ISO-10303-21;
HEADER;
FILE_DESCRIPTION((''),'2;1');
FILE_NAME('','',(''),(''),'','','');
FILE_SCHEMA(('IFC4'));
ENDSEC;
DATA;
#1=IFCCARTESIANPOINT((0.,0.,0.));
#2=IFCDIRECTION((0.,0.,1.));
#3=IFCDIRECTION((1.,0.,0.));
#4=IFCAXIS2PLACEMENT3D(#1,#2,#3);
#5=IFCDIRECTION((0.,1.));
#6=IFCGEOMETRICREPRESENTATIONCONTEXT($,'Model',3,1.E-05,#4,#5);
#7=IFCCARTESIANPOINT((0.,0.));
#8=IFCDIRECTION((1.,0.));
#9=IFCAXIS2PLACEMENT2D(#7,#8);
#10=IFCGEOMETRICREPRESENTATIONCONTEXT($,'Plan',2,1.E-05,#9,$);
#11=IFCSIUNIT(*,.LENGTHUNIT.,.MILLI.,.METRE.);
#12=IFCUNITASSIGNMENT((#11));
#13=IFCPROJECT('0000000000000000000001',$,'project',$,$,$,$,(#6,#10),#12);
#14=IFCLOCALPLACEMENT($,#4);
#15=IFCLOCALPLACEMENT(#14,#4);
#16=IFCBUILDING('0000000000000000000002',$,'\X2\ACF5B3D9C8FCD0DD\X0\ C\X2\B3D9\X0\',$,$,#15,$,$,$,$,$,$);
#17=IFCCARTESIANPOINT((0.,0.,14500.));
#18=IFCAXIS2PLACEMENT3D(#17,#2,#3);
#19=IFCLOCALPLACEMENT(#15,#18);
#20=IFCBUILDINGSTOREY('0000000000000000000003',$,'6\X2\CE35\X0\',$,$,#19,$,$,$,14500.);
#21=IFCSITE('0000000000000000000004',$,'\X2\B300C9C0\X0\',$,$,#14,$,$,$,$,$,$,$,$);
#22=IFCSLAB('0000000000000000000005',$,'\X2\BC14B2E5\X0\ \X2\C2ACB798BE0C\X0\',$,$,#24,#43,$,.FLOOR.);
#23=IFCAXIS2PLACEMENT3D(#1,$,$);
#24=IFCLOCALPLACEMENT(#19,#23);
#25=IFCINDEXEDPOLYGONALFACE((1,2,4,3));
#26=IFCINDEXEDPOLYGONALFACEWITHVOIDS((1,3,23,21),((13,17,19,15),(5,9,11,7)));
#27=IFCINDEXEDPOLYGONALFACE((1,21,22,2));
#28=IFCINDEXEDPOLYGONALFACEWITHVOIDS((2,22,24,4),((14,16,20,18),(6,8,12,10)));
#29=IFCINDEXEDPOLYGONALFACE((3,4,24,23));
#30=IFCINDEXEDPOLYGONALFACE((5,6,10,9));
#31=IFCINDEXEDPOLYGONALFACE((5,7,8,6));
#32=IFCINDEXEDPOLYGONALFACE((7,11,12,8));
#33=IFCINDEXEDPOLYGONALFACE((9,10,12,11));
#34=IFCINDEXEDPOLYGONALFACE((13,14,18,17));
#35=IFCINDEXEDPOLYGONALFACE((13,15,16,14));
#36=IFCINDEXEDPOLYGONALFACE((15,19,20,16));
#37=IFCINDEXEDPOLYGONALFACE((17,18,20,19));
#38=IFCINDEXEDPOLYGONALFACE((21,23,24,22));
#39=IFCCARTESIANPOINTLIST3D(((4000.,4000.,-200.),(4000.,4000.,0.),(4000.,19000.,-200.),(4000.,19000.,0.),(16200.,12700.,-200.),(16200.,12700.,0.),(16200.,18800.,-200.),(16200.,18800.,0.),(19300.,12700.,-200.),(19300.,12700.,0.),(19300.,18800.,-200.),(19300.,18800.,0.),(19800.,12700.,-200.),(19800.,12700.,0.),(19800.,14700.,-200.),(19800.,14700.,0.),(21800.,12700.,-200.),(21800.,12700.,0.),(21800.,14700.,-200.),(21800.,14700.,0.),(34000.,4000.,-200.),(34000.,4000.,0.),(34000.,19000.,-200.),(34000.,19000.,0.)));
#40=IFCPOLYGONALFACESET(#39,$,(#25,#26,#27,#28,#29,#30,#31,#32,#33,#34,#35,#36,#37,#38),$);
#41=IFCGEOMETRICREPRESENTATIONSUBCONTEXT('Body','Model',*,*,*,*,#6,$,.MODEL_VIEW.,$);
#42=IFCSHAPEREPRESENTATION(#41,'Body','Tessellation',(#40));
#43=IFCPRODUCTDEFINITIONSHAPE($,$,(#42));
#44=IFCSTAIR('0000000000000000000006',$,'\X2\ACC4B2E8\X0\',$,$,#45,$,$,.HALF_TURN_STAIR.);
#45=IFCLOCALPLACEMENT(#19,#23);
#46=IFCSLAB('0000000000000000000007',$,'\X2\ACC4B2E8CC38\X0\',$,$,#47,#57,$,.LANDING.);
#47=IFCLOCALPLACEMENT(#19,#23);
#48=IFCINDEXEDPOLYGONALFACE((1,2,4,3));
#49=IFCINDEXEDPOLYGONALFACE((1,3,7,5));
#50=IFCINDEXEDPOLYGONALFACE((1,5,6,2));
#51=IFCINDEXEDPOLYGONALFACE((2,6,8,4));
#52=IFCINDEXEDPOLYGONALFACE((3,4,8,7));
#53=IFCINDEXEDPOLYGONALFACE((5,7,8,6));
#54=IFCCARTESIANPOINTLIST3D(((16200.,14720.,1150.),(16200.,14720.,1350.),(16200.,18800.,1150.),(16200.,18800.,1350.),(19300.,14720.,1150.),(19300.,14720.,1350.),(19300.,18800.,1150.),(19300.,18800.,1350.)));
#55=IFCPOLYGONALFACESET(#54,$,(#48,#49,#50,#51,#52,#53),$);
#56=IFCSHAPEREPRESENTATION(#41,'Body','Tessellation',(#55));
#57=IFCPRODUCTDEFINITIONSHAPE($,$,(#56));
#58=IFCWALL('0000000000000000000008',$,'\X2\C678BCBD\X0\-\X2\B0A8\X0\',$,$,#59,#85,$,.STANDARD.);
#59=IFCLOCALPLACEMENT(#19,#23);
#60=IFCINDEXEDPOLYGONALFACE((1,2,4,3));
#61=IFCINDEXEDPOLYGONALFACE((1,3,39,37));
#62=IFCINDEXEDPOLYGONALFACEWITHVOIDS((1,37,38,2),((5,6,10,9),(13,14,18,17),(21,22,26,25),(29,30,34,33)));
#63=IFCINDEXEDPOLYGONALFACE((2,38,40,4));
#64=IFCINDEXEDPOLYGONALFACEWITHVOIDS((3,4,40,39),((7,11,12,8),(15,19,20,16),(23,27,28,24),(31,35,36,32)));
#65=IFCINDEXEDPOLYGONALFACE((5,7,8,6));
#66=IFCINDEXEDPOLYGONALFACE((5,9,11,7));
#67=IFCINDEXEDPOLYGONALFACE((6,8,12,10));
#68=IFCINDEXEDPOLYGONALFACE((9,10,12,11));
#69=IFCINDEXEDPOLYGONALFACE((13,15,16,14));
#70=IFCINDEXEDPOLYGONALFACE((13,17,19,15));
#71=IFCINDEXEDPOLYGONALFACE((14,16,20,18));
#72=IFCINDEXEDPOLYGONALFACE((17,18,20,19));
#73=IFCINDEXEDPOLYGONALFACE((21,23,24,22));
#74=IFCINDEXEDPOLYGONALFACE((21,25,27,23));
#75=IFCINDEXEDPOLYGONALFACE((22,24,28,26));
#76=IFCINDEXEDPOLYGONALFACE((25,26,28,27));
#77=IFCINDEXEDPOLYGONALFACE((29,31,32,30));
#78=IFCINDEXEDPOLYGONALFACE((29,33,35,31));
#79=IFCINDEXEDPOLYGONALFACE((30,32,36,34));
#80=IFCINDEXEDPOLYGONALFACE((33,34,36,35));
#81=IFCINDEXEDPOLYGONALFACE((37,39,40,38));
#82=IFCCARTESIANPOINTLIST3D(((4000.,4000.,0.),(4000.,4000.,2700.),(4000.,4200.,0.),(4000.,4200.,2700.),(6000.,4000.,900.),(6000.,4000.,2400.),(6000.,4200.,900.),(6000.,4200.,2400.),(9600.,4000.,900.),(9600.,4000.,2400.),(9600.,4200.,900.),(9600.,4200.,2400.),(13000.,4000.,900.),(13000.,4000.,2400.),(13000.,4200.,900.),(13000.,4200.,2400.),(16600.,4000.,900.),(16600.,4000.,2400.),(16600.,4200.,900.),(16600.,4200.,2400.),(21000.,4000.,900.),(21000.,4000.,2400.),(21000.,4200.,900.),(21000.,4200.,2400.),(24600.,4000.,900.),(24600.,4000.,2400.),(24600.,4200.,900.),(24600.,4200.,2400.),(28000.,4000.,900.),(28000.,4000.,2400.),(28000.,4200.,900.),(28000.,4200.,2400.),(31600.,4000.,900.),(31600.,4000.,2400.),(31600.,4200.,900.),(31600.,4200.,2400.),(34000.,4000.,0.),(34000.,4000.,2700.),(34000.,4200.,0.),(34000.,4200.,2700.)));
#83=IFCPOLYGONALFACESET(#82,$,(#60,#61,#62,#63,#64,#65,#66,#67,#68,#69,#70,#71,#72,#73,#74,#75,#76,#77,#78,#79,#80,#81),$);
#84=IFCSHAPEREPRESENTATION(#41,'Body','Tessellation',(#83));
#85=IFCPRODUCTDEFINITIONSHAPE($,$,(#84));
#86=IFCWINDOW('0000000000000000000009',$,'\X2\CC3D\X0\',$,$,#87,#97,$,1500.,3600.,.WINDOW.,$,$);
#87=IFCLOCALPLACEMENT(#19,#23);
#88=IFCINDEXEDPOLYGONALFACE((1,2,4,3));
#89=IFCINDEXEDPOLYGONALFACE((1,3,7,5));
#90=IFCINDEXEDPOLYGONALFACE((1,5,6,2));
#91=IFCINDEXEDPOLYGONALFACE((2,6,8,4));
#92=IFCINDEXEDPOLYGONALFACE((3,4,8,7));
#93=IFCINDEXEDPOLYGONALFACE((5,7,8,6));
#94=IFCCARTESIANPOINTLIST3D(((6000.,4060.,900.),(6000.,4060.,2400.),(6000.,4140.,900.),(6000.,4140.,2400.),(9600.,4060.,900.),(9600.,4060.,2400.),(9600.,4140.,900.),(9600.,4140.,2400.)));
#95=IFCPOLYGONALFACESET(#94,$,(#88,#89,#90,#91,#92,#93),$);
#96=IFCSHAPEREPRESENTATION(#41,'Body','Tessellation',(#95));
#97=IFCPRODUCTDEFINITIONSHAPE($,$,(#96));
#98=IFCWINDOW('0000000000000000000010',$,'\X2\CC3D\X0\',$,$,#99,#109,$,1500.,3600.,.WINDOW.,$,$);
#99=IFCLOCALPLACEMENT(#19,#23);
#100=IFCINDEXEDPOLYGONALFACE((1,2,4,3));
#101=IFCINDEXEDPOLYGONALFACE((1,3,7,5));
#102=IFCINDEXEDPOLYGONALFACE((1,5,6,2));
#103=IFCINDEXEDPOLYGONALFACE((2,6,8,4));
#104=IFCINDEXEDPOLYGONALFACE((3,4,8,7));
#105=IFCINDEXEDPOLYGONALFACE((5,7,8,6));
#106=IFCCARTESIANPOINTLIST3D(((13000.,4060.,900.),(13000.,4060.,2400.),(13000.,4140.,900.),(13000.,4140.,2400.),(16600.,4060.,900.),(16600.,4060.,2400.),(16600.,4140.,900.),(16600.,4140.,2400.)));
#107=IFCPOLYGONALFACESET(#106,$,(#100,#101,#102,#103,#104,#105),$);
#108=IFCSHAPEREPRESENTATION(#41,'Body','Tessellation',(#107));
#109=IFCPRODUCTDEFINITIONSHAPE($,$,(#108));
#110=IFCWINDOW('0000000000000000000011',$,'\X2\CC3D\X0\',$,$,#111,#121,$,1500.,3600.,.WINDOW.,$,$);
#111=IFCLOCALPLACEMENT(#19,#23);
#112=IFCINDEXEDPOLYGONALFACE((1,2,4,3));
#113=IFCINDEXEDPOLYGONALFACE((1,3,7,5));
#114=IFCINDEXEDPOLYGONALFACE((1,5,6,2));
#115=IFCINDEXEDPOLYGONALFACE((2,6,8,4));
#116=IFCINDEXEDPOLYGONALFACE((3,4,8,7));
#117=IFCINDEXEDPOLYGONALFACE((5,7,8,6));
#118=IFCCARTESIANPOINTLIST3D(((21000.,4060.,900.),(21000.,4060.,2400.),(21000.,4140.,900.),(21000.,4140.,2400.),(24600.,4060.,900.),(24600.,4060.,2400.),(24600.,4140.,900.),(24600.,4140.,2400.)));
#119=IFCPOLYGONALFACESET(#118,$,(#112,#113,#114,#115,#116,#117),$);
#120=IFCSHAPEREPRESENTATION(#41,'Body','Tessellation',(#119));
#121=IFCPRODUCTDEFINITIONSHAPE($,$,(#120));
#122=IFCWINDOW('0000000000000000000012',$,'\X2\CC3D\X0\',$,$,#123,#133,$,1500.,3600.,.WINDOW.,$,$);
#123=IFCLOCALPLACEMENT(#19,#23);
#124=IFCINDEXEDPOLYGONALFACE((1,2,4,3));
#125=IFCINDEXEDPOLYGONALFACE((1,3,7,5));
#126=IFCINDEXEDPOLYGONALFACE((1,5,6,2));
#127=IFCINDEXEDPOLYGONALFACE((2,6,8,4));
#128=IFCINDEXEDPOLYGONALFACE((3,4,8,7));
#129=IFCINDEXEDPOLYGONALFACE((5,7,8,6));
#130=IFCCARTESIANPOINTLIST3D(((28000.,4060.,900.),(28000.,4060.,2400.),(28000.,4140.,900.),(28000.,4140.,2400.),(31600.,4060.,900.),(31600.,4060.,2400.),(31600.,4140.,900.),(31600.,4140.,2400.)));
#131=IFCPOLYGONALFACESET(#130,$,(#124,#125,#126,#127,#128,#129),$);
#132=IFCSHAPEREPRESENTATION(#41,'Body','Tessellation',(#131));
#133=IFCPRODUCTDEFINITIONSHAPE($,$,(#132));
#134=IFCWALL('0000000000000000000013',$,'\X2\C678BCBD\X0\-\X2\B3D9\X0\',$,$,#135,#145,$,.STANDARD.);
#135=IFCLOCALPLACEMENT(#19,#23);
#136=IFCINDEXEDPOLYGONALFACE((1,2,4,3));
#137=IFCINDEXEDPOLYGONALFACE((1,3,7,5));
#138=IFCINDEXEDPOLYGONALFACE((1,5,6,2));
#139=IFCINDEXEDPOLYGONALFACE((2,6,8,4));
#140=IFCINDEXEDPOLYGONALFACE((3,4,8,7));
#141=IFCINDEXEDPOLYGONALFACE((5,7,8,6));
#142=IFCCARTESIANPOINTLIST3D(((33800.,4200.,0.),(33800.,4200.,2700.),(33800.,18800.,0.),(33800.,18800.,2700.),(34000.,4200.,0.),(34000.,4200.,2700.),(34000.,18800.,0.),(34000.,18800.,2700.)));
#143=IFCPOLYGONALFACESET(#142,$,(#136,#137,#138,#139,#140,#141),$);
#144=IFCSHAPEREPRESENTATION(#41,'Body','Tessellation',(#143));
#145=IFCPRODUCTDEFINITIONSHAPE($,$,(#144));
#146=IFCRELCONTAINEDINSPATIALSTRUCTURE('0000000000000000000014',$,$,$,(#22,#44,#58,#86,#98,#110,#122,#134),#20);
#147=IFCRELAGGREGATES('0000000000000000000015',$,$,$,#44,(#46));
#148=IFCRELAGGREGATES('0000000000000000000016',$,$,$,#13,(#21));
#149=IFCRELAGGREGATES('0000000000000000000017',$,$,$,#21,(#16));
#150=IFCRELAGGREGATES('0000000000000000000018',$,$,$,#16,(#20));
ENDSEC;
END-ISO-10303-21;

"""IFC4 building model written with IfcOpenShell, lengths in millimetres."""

from ifc_helpers import new_model, si_unit, direction, frame, origin_with_axes, origin_2d_with_axis, place, context, subcontext, project, spatial, polyline, outline, extrude, element, fill, aggregate, save


model = new_model("IFC4")

# Units and contexts
model_context = context("Model", 3, precision=1e-05, world=origin_with_axes(), true_north=direction((0.0, 1.0)))
plan_context = context("Plan", 2, precision=1e-05, world=origin_2d_with_axis())
body_context = subcontext(model_context, "Body", "Model", "MODEL_VIEW")
ifc_project = project(units=[si_unit("LENGTHUNIT", "METRE", prefix="MILLI")], contexts=[model_context, plan_context])

# Site, building, storey
site_placement = place(None, origin_with_axes())
site = spatial("IfcSite", under=ifc_project, at=site_placement, Name="대지")
building_placement = place(site_placement, origin_with_axes())
building = spatial("IfcBuilding", under=site, at=building_placement, Name="공동주택 C동")
storey_placement = place(building_placement, frame((0.0, 0.0, 14500.0), z_axis=(0.0, 0.0, 1.0), x_axis=(1.0, 0.0, 0.0)))
storey = spatial("IfcBuildingStorey", under=building, at=storey_placement, Name="6층", Elevation=14500.0)

# Slab
slab_1_placement = place(storey_placement, origin_with_axes())
element("IfcSlab", 1, at=slab_1_placement, inside=storey, Name="바닥 슬래브", PredefinedType="FLOOR", context=body_context, shape_type="SweptSolid", body=[
    extrude(outline(polyline([(4000.0, 4000.0), (34000.0, 4000.0), (34000.0, 19000.0), (4000.0, 19000.0), (4000.0, 4000.0)]), holes=[polyline([(16200.0, 12700.0), (19300.0, 12700.0), (19300.0, 18800.0), (16200.0, 18800.0), (16200.0, 12700.0)]), polyline([(19800.0, 12700.0), (21800.0, 12700.0), (21800.0, 14700.0), (19800.0, 14700.0), (19800.0, 12700.0)])]), frame((0.0, 0.0, -200.0), z_axis=(0.0, 0.0, 1.0), x_axis=(1.0, 0.0, 0.0)), (0.0, 0.0, 1.0), 200.0),
])

# Stair, slab
stair_placement = place(storey_placement, origin_with_axes())
stair = element("IfcStair", 2, at=stair_placement, inside=storey, Name="계단", PredefinedType="HALF_TURN_STAIR")
slab_2_placement = place(stair_placement, origin_with_axes())
slab_2 = element("IfcSlab", 3, at=slab_2_placement, Name="계단참", PredefinedType="LANDING", context=body_context, shape_type="SweptSolid", body=[
    extrude(outline(polyline([(16200.0, 14720.0), (19300.0, 14720.0), (19300.0, 18800.0), (16200.0, 18800.0), (16200.0, 14720.0)])), frame((0.0, 0.0, 1150.0), z_axis=(0.0, 0.0, 1.0), x_axis=(1.0, 0.0, 0.0)), (0.0, 0.0, 1.0), 200.0),
])

# Wall, openings, windows
wall_1_placement = place(storey_placement, origin_with_axes())
wall_1 = element("IfcWall", 4, at=wall_1_placement, inside=storey, Name="외벽-남", PredefinedType="STANDARD", context=body_context, shape_type="SweptSolid", body=[
    extrude(outline(polyline([(4000.0, 4200.0), (34000.0, 4200.0), (34000.0, 4000.0), (4000.0, 4000.0), (4000.0, 4200.0)])), origin_with_axes(), (0.0, 0.0, 1.0), 2700.0),
])
opening_1_placement = place(storey_placement, origin_with_axes())
opening_1 = element("IfcOpeningElement", 5, at=opening_1_placement, cuts=wall_1, PredefinedType="OPENING", context=body_context, shape_type="SweptSolid", body=[
    extrude(outline(polyline([(6000.0, 3950.0), (9600.0, 3950.0), (9600.0, 4250.0), (6000.0, 4250.0), (6000.0, 3950.0)])), frame((0.0, 0.0, 900.0), z_axis=(0.0, 0.0, 1.0), x_axis=(1.0, 0.0, 0.0)), (0.0, 0.0, 1.0), 1500.0),
])
opening_2_placement = place(storey_placement, origin_with_axes())
opening_2 = element("IfcOpeningElement", 6, at=opening_2_placement, cuts=wall_1, PredefinedType="OPENING", context=body_context, shape_type="SweptSolid", body=[
    extrude(outline(polyline([(13000.0, 3950.0), (16600.0, 3950.0), (16600.0, 4250.0), (13000.0, 4250.0), (13000.0, 3950.0)])), frame((0.0, 0.0, 900.0), z_axis=(0.0, 0.0, 1.0), x_axis=(1.0, 0.0, 0.0)), (0.0, 0.0, 1.0), 1500.0),
])
opening_3_placement = place(storey_placement, origin_with_axes())
opening_3 = element("IfcOpeningElement", 7, at=opening_3_placement, cuts=wall_1, PredefinedType="OPENING", context=body_context, shape_type="SweptSolid", body=[
    extrude(outline(polyline([(21000.0, 3950.0), (24600.0, 3950.0), (24600.0, 4250.0), (21000.0, 4250.0), (21000.0, 3950.0)])), frame((0.0, 0.0, 900.0), z_axis=(0.0, 0.0, 1.0), x_axis=(1.0, 0.0, 0.0)), (0.0, 0.0, 1.0), 1500.0),
])
opening_4_placement = place(storey_placement, origin_with_axes())
opening_4 = element("IfcOpeningElement", 8, at=opening_4_placement, cuts=wall_1, PredefinedType="OPENING", context=body_context, shape_type="SweptSolid", body=[
    extrude(outline(polyline([(28000.0, 3950.0), (31600.0, 3950.0), (31600.0, 4250.0), (28000.0, 4250.0), (28000.0, 3950.0)])), frame((0.0, 0.0, 900.0), z_axis=(0.0, 0.0, 1.0), x_axis=(1.0, 0.0, 0.0)), (0.0, 0.0, 1.0), 1500.0),
])
window_1_placement = place(storey_placement, origin_with_axes())
window_1 = element("IfcWindow", 9, at=window_1_placement, inside=storey, Name="창", OverallHeight=1500.0, OverallWidth=3600.0, PredefinedType="WINDOW", context=body_context, shape_type="SweptSolid", body=[
    extrude(outline(polyline([(6000.0, 4060.0), (9600.0, 4060.0), (9600.0, 4140.0), (6000.0, 4140.0), (6000.0, 4060.0)])), frame((0.0, 0.0, 900.0), z_axis=(0.0, 0.0, 1.0), x_axis=(1.0, 0.0, 0.0)), (0.0, 0.0, 1.0), 1500.0),
])
fill(opening_1, window_1)
window_2_placement = place(storey_placement, origin_with_axes())
window_2 = element("IfcWindow", 10, at=window_2_placement, inside=storey, Name="창", OverallHeight=1500.0, OverallWidth=3600.0, PredefinedType="WINDOW", context=body_context, shape_type="SweptSolid", body=[
    extrude(outline(polyline([(13000.0, 4060.0), (16600.0, 4060.0), (16600.0, 4140.0), (13000.0, 4140.0), (13000.0, 4060.0)])), frame((0.0, 0.0, 900.0), z_axis=(0.0, 0.0, 1.0), x_axis=(1.0, 0.0, 0.0)), (0.0, 0.0, 1.0), 1500.0),
])
fill(opening_2, window_2)
window_3_placement = place(storey_placement, origin_with_axes())
window_3 = element("IfcWindow", 11, at=window_3_placement, inside=storey, Name="창", OverallHeight=1500.0, OverallWidth=3600.0, PredefinedType="WINDOW", context=body_context, shape_type="SweptSolid", body=[
    extrude(outline(polyline([(21000.0, 4060.0), (24600.0, 4060.0), (24600.0, 4140.0), (21000.0, 4140.0), (21000.0, 4060.0)])), frame((0.0, 0.0, 900.0), z_axis=(0.0, 0.0, 1.0), x_axis=(1.0, 0.0, 0.0)), (0.0, 0.0, 1.0), 1500.0),
])
fill(opening_3, window_3)
window_4_placement = place(storey_placement, origin_with_axes())
window_4 = element("IfcWindow", 12, at=window_4_placement, inside=storey, Name="창", OverallHeight=1500.0, OverallWidth=3600.0, PredefinedType="WINDOW", context=body_context, shape_type="SweptSolid", body=[
    extrude(outline(polyline([(28000.0, 4060.0), (31600.0, 4060.0), (31600.0, 4140.0), (28000.0, 4140.0), (28000.0, 4060.0)])), frame((0.0, 0.0, 900.0), z_axis=(0.0, 0.0, 1.0), x_axis=(1.0, 0.0, 0.0)), (0.0, 0.0, 1.0), 1500.0),
])
fill(opening_4, window_4)

# Wall
wall_2_placement = place(storey_placement, origin_with_axes())
element("IfcWall", 13, at=wall_2_placement, inside=storey, Name="외벽-동", PredefinedType="STANDARD", context=body_context, shape_type="SweptSolid", body=[
    extrude(outline(polyline([(33800.0, 4200.0), (33800.0, 18800.0), (34000.0, 18800.0), (34000.0, 4200.0), (33800.0, 4200.0)])), origin_with_axes(), (0.0, 0.0, 1.0), 2700.0),
])

aggregate(stair, [slab_2])

save(model, "model.ifc")
